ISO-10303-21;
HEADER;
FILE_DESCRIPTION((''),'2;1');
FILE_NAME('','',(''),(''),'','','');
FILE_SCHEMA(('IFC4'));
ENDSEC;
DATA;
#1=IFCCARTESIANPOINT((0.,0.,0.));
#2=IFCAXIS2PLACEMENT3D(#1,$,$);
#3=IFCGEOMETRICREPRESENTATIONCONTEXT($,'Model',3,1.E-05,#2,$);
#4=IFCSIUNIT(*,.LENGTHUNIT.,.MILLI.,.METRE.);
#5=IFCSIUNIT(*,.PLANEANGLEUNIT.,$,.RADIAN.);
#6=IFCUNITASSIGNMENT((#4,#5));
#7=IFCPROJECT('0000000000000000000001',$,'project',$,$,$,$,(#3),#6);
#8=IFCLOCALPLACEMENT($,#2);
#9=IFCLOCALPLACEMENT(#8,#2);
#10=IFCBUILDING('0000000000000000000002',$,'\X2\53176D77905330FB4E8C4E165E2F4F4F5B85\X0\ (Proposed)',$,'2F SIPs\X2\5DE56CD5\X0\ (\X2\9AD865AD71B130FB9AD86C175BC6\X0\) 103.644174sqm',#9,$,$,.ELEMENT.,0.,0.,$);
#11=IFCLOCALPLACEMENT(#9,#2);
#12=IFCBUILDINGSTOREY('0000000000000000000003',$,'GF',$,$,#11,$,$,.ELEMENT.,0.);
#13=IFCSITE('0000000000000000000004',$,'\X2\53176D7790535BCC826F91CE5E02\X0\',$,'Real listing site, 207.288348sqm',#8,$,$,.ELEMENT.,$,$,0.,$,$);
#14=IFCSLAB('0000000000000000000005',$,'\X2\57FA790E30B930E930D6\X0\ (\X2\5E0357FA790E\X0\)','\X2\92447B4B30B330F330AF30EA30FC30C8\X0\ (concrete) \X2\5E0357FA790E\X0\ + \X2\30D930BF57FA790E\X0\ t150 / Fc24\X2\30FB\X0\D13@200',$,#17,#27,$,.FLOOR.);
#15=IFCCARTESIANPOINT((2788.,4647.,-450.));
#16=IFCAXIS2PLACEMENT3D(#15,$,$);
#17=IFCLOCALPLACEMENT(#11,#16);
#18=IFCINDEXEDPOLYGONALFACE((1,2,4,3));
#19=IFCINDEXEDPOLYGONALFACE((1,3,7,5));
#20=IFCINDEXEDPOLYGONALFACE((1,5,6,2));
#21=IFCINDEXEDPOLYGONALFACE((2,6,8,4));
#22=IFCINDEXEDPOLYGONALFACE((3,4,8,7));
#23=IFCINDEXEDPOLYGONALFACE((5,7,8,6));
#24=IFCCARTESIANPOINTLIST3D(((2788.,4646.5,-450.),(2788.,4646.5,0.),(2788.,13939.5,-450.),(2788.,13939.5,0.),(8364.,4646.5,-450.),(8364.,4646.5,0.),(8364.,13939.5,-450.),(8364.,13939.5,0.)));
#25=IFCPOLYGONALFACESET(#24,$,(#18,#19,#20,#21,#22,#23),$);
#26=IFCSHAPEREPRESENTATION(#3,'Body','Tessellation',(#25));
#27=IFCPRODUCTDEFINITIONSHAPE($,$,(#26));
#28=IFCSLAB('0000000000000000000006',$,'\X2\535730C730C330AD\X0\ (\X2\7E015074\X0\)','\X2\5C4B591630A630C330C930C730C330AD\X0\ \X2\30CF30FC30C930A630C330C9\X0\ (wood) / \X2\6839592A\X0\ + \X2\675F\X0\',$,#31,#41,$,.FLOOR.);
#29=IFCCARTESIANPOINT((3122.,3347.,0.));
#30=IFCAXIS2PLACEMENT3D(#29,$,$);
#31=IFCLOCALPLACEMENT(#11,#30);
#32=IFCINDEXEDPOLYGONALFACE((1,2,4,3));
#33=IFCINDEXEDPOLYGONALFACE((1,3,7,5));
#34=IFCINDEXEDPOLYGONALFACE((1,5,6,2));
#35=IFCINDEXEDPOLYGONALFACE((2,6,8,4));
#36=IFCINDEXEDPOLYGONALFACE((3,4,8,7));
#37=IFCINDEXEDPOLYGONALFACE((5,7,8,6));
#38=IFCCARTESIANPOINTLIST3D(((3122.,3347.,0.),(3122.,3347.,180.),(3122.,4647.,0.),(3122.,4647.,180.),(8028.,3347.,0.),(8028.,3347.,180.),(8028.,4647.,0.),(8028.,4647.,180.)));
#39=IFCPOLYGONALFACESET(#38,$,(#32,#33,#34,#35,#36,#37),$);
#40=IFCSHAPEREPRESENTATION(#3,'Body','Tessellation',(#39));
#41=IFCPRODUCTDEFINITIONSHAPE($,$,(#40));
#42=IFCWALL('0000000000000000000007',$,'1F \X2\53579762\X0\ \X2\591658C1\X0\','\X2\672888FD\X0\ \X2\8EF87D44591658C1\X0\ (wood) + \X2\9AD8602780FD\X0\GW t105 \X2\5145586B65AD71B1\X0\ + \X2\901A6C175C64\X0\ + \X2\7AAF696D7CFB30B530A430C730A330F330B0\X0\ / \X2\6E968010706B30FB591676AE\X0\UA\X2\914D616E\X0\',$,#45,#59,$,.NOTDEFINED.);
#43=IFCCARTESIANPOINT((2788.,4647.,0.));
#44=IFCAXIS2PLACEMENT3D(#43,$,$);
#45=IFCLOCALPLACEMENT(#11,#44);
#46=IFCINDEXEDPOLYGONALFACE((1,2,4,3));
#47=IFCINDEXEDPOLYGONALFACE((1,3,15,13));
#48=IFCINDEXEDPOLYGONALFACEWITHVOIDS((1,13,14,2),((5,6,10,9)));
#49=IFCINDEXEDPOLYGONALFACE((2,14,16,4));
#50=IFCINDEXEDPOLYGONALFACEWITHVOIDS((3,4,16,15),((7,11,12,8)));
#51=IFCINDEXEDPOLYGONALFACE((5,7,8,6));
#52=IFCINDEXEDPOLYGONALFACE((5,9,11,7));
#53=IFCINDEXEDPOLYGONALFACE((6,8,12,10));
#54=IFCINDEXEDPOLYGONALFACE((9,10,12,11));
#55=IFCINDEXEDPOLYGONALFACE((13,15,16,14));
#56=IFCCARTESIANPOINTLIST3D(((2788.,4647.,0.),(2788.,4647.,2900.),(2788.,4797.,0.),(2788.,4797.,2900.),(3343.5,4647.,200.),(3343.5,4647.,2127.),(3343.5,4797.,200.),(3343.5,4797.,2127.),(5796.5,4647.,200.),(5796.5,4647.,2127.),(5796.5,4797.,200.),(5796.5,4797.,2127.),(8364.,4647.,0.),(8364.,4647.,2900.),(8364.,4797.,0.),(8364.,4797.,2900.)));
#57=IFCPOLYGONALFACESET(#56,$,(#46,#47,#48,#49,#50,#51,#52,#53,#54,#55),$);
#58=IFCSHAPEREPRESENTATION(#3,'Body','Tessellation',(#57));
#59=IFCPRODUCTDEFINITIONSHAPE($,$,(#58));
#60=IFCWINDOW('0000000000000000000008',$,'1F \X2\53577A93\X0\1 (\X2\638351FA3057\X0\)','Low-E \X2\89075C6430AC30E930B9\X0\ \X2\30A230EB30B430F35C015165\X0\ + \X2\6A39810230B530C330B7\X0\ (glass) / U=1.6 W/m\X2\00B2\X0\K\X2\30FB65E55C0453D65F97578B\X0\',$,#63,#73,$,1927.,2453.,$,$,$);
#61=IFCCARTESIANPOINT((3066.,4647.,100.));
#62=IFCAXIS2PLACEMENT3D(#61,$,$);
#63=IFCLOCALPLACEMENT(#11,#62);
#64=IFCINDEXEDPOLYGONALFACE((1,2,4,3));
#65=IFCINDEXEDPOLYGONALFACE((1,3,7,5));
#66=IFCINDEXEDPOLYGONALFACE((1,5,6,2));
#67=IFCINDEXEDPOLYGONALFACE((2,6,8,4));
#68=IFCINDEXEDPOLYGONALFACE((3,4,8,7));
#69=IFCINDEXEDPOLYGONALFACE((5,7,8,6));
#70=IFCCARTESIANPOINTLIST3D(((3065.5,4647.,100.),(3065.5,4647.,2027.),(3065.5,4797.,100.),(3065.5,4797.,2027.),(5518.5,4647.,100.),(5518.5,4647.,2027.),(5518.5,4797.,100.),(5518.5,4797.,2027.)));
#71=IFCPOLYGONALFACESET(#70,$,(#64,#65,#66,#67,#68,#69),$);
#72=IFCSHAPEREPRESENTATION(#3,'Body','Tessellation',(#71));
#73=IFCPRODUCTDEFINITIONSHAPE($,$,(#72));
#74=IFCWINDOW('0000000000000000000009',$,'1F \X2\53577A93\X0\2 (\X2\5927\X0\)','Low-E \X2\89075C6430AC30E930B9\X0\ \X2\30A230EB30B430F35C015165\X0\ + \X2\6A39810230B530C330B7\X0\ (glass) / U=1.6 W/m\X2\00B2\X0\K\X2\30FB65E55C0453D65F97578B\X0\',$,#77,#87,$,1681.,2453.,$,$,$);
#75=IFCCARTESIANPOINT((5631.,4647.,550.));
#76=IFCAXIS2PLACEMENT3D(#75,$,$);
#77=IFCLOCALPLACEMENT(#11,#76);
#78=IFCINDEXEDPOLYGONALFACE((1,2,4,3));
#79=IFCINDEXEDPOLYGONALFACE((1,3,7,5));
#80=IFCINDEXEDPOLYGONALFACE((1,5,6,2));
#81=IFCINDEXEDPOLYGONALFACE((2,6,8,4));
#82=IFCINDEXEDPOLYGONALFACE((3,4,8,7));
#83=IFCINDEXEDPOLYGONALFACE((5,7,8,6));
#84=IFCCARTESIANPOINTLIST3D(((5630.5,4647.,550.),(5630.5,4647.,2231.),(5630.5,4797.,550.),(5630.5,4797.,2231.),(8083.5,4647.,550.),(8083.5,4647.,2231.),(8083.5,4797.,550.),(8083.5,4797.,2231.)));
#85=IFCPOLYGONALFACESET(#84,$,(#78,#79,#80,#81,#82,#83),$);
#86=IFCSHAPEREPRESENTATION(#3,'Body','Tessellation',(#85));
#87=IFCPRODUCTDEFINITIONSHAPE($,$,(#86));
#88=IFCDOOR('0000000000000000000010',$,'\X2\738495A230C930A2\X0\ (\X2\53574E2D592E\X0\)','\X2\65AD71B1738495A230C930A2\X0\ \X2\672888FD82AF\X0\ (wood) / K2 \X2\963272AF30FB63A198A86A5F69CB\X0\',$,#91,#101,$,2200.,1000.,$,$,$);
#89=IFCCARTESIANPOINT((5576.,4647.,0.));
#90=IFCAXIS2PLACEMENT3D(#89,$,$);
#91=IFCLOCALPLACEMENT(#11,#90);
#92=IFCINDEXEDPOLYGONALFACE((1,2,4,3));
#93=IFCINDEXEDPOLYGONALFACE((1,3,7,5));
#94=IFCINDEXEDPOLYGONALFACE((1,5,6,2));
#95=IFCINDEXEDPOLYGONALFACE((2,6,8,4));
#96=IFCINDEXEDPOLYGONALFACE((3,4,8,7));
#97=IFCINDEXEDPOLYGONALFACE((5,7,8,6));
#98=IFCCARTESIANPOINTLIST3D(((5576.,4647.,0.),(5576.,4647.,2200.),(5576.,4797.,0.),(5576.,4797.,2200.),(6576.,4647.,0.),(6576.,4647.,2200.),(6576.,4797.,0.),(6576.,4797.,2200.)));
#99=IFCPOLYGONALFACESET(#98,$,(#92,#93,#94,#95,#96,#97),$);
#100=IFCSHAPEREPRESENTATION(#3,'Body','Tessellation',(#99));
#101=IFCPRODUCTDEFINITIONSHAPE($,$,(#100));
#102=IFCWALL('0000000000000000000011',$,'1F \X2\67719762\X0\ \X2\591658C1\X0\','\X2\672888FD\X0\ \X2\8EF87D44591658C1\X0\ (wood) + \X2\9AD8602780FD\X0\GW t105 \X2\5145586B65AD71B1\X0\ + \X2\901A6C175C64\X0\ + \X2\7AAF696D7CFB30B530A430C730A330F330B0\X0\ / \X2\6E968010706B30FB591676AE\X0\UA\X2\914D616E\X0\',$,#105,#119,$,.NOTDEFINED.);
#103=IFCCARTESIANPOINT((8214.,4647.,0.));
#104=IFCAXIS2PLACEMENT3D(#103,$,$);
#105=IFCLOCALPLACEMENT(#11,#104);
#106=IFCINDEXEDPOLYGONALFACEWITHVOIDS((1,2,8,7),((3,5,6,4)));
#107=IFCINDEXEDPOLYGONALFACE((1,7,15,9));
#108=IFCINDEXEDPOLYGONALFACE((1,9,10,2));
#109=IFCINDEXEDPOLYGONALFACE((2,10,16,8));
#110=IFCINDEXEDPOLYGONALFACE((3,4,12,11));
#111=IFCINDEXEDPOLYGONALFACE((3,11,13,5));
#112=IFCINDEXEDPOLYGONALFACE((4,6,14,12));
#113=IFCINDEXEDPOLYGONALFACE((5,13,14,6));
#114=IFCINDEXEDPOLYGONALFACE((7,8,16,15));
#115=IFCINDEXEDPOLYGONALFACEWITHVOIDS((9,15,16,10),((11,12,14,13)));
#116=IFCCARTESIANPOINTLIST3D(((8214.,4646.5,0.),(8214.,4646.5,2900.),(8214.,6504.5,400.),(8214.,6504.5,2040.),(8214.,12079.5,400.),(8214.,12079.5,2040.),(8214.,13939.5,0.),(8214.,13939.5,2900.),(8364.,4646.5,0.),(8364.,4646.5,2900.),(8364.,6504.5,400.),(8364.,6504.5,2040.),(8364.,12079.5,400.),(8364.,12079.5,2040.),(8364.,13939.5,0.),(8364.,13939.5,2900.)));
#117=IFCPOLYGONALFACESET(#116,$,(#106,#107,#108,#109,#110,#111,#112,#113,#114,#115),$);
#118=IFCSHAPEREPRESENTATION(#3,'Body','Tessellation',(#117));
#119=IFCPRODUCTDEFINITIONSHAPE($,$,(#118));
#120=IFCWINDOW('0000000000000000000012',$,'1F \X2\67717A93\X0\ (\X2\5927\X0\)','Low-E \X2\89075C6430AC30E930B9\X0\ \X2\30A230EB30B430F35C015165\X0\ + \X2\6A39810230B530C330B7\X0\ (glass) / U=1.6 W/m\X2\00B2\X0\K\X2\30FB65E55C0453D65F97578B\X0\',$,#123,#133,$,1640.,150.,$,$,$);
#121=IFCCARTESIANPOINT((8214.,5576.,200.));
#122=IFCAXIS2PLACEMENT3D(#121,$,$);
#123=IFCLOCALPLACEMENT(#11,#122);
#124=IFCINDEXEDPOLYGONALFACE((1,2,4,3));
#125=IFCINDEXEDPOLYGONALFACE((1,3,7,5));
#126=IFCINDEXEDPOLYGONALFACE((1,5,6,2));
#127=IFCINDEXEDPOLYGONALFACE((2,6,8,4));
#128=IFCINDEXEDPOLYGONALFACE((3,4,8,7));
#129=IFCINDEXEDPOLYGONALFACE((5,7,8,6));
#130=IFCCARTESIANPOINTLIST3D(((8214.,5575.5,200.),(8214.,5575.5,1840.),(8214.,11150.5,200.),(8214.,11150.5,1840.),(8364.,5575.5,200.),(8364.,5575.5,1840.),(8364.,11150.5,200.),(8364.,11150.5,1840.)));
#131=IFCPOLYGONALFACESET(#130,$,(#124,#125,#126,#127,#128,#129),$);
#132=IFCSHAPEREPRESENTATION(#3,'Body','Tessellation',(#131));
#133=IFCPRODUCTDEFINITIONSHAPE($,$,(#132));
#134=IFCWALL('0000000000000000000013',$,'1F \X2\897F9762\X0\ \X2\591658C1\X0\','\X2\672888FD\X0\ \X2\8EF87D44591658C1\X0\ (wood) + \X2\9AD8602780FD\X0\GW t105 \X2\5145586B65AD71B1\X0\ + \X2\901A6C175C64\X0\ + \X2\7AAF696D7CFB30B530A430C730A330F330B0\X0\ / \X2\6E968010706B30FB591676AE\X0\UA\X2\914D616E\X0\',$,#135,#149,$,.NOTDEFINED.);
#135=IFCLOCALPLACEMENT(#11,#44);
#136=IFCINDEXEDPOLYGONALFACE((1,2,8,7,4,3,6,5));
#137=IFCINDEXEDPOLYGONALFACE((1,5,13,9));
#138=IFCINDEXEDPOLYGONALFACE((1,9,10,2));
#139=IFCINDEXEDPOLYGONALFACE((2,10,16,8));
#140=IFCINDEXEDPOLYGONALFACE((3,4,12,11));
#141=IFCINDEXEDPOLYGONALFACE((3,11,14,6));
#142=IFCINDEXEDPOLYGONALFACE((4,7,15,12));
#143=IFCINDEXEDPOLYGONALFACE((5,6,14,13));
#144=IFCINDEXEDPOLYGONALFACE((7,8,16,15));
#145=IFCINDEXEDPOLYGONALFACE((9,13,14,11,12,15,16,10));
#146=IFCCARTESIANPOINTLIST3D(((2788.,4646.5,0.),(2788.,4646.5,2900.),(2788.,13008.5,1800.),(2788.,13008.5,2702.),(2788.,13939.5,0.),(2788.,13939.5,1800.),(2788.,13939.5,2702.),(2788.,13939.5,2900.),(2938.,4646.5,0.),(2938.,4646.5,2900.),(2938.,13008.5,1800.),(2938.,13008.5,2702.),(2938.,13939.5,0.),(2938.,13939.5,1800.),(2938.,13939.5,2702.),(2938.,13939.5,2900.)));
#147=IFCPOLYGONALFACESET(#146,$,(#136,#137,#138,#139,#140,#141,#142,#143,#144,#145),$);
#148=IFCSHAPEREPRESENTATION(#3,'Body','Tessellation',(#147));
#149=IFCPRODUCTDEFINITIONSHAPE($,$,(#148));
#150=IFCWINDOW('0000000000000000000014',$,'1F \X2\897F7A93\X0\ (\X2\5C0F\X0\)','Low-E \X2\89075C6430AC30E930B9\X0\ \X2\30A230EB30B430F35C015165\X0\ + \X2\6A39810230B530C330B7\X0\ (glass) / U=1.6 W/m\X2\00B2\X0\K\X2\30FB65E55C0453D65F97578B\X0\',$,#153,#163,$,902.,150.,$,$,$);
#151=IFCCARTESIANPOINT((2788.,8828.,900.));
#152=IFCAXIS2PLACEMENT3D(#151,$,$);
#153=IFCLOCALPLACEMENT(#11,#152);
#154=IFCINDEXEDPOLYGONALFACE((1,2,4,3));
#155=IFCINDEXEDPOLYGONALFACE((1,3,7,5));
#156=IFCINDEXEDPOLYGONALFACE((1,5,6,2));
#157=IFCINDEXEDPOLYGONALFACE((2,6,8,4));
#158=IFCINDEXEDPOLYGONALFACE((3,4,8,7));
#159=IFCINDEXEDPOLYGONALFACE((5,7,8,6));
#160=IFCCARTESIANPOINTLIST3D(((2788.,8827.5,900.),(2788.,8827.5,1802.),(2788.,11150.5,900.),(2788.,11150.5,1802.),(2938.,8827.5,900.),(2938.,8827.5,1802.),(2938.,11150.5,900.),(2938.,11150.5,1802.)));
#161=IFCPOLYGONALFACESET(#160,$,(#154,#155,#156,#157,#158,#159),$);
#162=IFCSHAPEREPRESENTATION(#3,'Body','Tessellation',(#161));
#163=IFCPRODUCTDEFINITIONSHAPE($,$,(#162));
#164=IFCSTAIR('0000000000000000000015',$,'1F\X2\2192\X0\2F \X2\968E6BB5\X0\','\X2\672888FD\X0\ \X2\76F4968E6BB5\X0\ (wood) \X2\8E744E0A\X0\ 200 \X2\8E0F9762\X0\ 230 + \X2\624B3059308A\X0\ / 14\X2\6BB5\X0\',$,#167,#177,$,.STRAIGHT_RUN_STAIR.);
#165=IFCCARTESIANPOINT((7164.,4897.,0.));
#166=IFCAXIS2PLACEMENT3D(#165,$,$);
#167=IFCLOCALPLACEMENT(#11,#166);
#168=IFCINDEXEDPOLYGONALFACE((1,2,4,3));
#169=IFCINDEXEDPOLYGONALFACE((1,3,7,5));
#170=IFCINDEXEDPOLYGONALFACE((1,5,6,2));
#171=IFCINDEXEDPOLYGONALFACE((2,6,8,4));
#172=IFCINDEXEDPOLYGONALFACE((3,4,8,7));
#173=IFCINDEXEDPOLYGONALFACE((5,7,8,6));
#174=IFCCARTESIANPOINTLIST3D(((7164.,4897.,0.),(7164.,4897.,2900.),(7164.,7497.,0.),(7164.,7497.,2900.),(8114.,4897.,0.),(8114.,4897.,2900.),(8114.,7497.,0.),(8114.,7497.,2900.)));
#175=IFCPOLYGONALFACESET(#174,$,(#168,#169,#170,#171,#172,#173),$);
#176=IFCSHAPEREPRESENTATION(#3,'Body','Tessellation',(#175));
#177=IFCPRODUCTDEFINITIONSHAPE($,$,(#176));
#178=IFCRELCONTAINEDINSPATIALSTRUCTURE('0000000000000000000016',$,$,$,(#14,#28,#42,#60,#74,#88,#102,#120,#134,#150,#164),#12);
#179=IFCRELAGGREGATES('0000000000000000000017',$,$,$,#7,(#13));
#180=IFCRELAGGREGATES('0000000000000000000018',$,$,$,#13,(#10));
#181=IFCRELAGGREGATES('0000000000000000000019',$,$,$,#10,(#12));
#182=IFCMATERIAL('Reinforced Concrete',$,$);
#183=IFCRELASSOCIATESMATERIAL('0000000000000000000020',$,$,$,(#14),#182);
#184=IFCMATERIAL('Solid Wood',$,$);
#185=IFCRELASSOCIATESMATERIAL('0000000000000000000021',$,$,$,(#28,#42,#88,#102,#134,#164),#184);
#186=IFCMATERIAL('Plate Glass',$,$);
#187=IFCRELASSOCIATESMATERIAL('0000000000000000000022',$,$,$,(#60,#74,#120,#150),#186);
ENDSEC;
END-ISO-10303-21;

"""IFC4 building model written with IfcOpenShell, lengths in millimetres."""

from ifc_helpers import new_model, si_unit, frame, frame_2d, origin, place, context, project, spatial, rectangle, extrude, material, element, fill, save


model = new_model("IFC4")

# Units and contexts
model_context = context("Model", 3, precision=1e-05, world=origin())
ifc_project = project(units=[si_unit("LENGTHUNIT", "METRE", prefix="MILLI"), si_unit("PLANEANGLEUNIT", "RADIAN")], contexts=[model_context])

# Site, building, storey
site_placement = place(None, origin())
site = spatial("IfcSite", under=ifc_project, at=site_placement, Name="北海道富良野市", ObjectType="Real listing site, 207.288348sqm", CompositionType="ELEMENT", RefElevation=0.0)
building_placement = place(site_placement, origin())
building = spatial("IfcBuilding", under=site, at=building_placement, Name="北海道・二世帯住宅 (Proposed)", ObjectType="2F SIPs工法 (高断熱・高気密) 103.644174sqm", CompositionType="ELEMENT", ElevationOfRefHeight=0.0, ElevationOfTerrain=0.0)
storey_placement = place(building_placement, origin())
storey = spatial("IfcBuildingStorey", under=building, at=storey_placement, Name="GF", CompositionType="ELEMENT", Elevation=0.0)

# Slabs
ifc_material_1 = material(Name="Reinforced Concrete")
slab_1_placement = place(storey_placement, frame((2788.0, 4647.0, -450.0)))
element("IfcSlab", 1, at=slab_1_placement, inside=storey, material=ifc_material_1, Name="基礎スラブ (布基礎)", Description="鉄筋コンクリート (concrete) 布基礎 + ベタ基礎 t150 / Fc24・D13@200", PredefinedType="FLOOR", context=model_context, shape_type="SweptSolid", body=[
    extrude(rectangle(XDim=5576.0, YDim=9293.0, at=frame_2d((2788.0, 4646.0))), frame((2788.0, 4647.0, -450.0)), (0.0, 0.0, 1.0), 450.0),
])
ifc_material_2 = material(Name="Solid Wood")
slab_2_placement = place(storey_placement, frame((3122.0, 3347.0, 0.0)))
element("IfcSlab", 2, at=slab_2_placement, inside=storey, material=ifc_material_2, Name="南デッキ (縁側)", Description="屋外ウッドデッキ ハードウッド (wood) / 根太 + 束", PredefinedType="FLOOR", context=model_context, shape_type="SweptSolid", body=[
    extrude(rectangle(XDim=4906.0, YDim=1300.0, at=frame_2d((2453.0, 650.0))), frame((3122.0, 3347.0, 0.0)), (0.0, 0.0, 1.0), 180.0),
])

# Wall, openings, windows, door
wall_1_placement = place(storey_placement, frame((2788.0, 4647.0, 0.0)))
wall_1 = element("IfcWall", 3, at=wall_1_placement, inside=storey, material=ifc_material_2, Name="1F 南面 外壁", Description="木製 軸組外壁 (wood) + 高性能GW t105 充填断熱 + 通気層 + 窯業系サイディング / 準耐火・外皮UA配慮", PredefinedType="NOTDEFINED", context=model_context, shape_type="SweptSolid", body=[
    extrude(rectangle(XDim=5576.0, YDim=150.0, at=frame_2d((2788.0, 75.0))), frame((2788.0, 4647.0, 0.0)), (0.0, 0.0, 1.0), 2900.0),
])
opening_1_placement = place(storey_placement, frame((3066.0, 4647.0, 100.0)))
opening_1 = element("IfcOpeningElement", 4, at=opening_1_placement, cuts=wall_1, PredefinedType="NOTDEFINED", context=model_context, shape_type="SweptSolid", body=[
    extrude(rectangle(XDim=2453.0, YDim=150.0, at=frame_2d((1226.0, 75.0))), frame((3066.0, 4647.0, 100.0)), (0.0, 0.0, 1.0), 1927.0),
])
opening_2_placement = place(storey_placement, frame((5631.0, 4647.0, 550.0)))
opening_2 = element("IfcOpeningElement", 5, at=opening_2_placement, cuts=wall_1, PredefinedType="NOTDEFINED", context=model_context, shape_type="SweptSolid", body=[
    extrude(rectangle(XDim=2453.0, YDim=150.0, at=frame_2d((1226.0, 75.0))), frame((5631.0, 4647.0, 550.0)), (0.0, 0.0, 1.0), 1681.0),
])
opening_3_placement = place(storey_placement, frame((5576.0, 4647.0, 0.0)))
opening_3 = element("IfcOpeningElement", 6, at=opening_3_placement, cuts=wall_1, PredefinedType="NOTDEFINED", context=model_context, shape_type="SweptSolid", body=[
    extrude(rectangle(XDim=1000.0, YDim=150.0, at=frame_2d((500.0, 75.0))), frame((5576.0, 4647.0, 0.0)), (0.0, 0.0, 1.0), 2200.0),
])
ifc_material_3 = material(Name="Plate Glass")
window_1_placement = place(storey_placement, frame((3066.0, 4647.0, 100.0)))
window_1 = element("IfcWindow", 7, at=window_1_placement, inside=storey, material=ifc_material_3, Name="1F 南窓1 (掃出し)", Description="Low-E 複層ガラス アルゴン封入 + 樹脂サッシ (glass) / U=1.6 W/m²K・日射取得型", OverallHeight=1927.0, OverallWidth=2453.0, context=model_context, shape_type="SweptSolid", body=[
    extrude(rectangle(XDim=2453.0, YDim=150.0, at=frame_2d((1226.0, 75.0))), frame((3066.0, 4647.0, 100.0)), (0.0, 0.0, 1.0), 1927.0),
])
fill(opening_1, window_1)
window_2_placement = place(storey_placement, frame((5631.0, 4647.0, 550.0)))
window_2 = element("IfcWindow", 8, at=window_2_placement, inside=storey, material=ifc_material_3, Name="1F 南窓2 (大)", Description="Low-E 複層ガラス アルゴン封入 + 樹脂サッシ (glass) / U=1.6 W/m²K・日射取得型", OverallHeight=1681.0, OverallWidth=2453.0, context=model_context, shape_type="SweptSolid", body=[
    extrude(rectangle(XDim=2453.0, YDim=150.0, at=frame_2d((1226.0, 75.0))), frame((5631.0, 4647.0, 550.0)), (0.0, 0.0, 1.0), 1681.0),
])
fill(opening_2, window_2)
door_placement = place(storey_placement, frame((5576.0, 4647.0, 0.0)))
door = element("IfcDoor", 9, at=door_placement, inside=storey, material=ifc_material_2, Name="玄関ドア (南中央)", Description="断熱玄関ドア 木製芯 (wood) / K2 防犯・採風機構", OverallHeight=2200.0, OverallWidth=1000.0, context=model_context, shape_type="SweptSolid", body=[
    extrude(rectangle(XDim=1000.0, YDim=150.0, at=frame_2d((500.0, 75.0))), frame((5576.0, 4647.0, 0.0)), (0.0, 0.0, 1.0), 2200.0),
])
fill(opening_3, door)

# Walls, openings, windows
wall_2_placement = place(storey_placement, frame((8214.0, 4647.0, 0.0)))
wall_2 = element("IfcWall", 10, at=wall_2_placement, inside=storey, material=ifc_material_2, Name="1F 東面 外壁", Description="木製 軸組外壁 (wood) + 高性能GW t105 充填断熱 + 通気層 + 窯業系サイディング / 準耐火・外皮UA配慮", PredefinedType="NOTDEFINED", context=model_context, shape_type="SweptSolid", body=[
    extrude(rectangle(XDim=150.0, YDim=9293.0, at=frame_2d((75.0, 4646.0))), frame((8214.0, 4647.0, 0.0)), (0.0, 0.0, 1.0), 2900.0),
])
opening_4_placement = place(storey_placement, frame((8214.0, 5576.0, 200.0)))
opening_4 = element("IfcOpeningElement", 11, at=opening_4_placement, cuts=wall_2, PredefinedType="NOTDEFINED", context=model_context, shape_type="SweptSolid", body=[
    extrude(rectangle(XDim=150.0, YDim=5575.0, at=frame_2d((75.0, 2787.0))), frame((8214.0, 5576.0, 200.0)), (0.0, 0.0, 1.0), 1640.0),
])
window_3_placement = place(storey_placement, frame((8214.0, 5576.0, 200.0)))
window_3 = element("IfcWindow", 12, at=window_3_placement, inside=storey, material=ifc_material_3, Name="1F 東窓 (大)", Description="Low-E 複層ガラス アルゴン封入 + 樹脂サッシ (glass) / U=1.6 W/m²K・日射取得型", OverallHeight=1640.0, OverallWidth=150.0, context=model_context, shape_type="SweptSolid", body=[
    extrude(rectangle(XDim=150.0, YDim=5575.0, at=frame_2d((75.0, 2787.0))), frame((8214.0, 5576.0, 200.0)), (0.0, 0.0, 1.0), 1640.0),
])
fill(opening_4, window_3)
wall_3_placement = place(storey_placement, frame((2788.0, 4647.0, 0.0)))
wall_3 = element("IfcWall", 13, at=wall_3_placement, inside=storey, material=ifc_material_2, Name="1F 西面 外壁", Description="木製 軸組外壁 (wood) + 高性能GW t105 充填断熱 + 通気層 + 窯業系サイディング / 準耐火・外皮UA配慮", PredefinedType="NOTDEFINED", context=model_context, shape_type="SweptSolid", body=[
    extrude(rectangle(XDim=150.0, YDim=9293.0, at=frame_2d((75.0, 4646.0))), frame((2788.0, 4647.0, 0.0)), (0.0, 0.0, 1.0), 2900.0),
])
opening_5_placement = place(storey_placement, frame((2788.0, 8828.0, 900.0)))
opening_5 = element("IfcOpeningElement", 14, at=opening_5_placement, cuts=wall_3, PredefinedType="NOTDEFINED", context=model_context, shape_type="SweptSolid", body=[
    extrude(rectangle(XDim=150.0, YDim=2323.0, at=frame_2d((75.0, 1161.0))), frame((2788.0, 8828.0, 900.0)), (0.0, 0.0, 1.0), 902.0),
])
window_4_placement = place(storey_placement, frame((2788.0, 8828.0, 900.0)))
window_4 = element("IfcWindow", 15, at=window_4_placement, inside=storey, material=ifc_material_3, Name="1F 西窓 (小)", Description="Low-E 複層ガラス アルゴン封入 + 樹脂サッシ (glass) / U=1.6 W/m²K・日射取得型", OverallHeight=902.0, OverallWidth=150.0, context=model_context, shape_type="SweptSolid", body=[
    extrude(rectangle(XDim=150.0, YDim=2323.0, at=frame_2d((75.0, 1161.0))), frame((2788.0, 8828.0, 900.0)), (0.0, 0.0, 1.0), 902.0),
])
fill(opening_5, window_4)

# Stair
stair_placement = place(storey_placement, frame((7164.0, 4897.0, 0.0)))
element("IfcStair", 16, at=stair_placement, inside=storey, material=ifc_material_2, Name="1F→2F 階段", Description="木製 直階段 (wood) 蹴上 200 踏面 230 + 手すり / 14段", PredefinedType="STRAIGHT_RUN_STAIR", context=model_context, shape_type="SweptSolid", body=[
    extrude(rectangle(XDim=950.0, YDim=2600.0, at=frame_2d((475.0, 1300.0))), frame((7164.0, 4897.0, 0.0)), (0.0, 0.0, 1.0), 2900.0),
])

save(model, "model.ifc")
